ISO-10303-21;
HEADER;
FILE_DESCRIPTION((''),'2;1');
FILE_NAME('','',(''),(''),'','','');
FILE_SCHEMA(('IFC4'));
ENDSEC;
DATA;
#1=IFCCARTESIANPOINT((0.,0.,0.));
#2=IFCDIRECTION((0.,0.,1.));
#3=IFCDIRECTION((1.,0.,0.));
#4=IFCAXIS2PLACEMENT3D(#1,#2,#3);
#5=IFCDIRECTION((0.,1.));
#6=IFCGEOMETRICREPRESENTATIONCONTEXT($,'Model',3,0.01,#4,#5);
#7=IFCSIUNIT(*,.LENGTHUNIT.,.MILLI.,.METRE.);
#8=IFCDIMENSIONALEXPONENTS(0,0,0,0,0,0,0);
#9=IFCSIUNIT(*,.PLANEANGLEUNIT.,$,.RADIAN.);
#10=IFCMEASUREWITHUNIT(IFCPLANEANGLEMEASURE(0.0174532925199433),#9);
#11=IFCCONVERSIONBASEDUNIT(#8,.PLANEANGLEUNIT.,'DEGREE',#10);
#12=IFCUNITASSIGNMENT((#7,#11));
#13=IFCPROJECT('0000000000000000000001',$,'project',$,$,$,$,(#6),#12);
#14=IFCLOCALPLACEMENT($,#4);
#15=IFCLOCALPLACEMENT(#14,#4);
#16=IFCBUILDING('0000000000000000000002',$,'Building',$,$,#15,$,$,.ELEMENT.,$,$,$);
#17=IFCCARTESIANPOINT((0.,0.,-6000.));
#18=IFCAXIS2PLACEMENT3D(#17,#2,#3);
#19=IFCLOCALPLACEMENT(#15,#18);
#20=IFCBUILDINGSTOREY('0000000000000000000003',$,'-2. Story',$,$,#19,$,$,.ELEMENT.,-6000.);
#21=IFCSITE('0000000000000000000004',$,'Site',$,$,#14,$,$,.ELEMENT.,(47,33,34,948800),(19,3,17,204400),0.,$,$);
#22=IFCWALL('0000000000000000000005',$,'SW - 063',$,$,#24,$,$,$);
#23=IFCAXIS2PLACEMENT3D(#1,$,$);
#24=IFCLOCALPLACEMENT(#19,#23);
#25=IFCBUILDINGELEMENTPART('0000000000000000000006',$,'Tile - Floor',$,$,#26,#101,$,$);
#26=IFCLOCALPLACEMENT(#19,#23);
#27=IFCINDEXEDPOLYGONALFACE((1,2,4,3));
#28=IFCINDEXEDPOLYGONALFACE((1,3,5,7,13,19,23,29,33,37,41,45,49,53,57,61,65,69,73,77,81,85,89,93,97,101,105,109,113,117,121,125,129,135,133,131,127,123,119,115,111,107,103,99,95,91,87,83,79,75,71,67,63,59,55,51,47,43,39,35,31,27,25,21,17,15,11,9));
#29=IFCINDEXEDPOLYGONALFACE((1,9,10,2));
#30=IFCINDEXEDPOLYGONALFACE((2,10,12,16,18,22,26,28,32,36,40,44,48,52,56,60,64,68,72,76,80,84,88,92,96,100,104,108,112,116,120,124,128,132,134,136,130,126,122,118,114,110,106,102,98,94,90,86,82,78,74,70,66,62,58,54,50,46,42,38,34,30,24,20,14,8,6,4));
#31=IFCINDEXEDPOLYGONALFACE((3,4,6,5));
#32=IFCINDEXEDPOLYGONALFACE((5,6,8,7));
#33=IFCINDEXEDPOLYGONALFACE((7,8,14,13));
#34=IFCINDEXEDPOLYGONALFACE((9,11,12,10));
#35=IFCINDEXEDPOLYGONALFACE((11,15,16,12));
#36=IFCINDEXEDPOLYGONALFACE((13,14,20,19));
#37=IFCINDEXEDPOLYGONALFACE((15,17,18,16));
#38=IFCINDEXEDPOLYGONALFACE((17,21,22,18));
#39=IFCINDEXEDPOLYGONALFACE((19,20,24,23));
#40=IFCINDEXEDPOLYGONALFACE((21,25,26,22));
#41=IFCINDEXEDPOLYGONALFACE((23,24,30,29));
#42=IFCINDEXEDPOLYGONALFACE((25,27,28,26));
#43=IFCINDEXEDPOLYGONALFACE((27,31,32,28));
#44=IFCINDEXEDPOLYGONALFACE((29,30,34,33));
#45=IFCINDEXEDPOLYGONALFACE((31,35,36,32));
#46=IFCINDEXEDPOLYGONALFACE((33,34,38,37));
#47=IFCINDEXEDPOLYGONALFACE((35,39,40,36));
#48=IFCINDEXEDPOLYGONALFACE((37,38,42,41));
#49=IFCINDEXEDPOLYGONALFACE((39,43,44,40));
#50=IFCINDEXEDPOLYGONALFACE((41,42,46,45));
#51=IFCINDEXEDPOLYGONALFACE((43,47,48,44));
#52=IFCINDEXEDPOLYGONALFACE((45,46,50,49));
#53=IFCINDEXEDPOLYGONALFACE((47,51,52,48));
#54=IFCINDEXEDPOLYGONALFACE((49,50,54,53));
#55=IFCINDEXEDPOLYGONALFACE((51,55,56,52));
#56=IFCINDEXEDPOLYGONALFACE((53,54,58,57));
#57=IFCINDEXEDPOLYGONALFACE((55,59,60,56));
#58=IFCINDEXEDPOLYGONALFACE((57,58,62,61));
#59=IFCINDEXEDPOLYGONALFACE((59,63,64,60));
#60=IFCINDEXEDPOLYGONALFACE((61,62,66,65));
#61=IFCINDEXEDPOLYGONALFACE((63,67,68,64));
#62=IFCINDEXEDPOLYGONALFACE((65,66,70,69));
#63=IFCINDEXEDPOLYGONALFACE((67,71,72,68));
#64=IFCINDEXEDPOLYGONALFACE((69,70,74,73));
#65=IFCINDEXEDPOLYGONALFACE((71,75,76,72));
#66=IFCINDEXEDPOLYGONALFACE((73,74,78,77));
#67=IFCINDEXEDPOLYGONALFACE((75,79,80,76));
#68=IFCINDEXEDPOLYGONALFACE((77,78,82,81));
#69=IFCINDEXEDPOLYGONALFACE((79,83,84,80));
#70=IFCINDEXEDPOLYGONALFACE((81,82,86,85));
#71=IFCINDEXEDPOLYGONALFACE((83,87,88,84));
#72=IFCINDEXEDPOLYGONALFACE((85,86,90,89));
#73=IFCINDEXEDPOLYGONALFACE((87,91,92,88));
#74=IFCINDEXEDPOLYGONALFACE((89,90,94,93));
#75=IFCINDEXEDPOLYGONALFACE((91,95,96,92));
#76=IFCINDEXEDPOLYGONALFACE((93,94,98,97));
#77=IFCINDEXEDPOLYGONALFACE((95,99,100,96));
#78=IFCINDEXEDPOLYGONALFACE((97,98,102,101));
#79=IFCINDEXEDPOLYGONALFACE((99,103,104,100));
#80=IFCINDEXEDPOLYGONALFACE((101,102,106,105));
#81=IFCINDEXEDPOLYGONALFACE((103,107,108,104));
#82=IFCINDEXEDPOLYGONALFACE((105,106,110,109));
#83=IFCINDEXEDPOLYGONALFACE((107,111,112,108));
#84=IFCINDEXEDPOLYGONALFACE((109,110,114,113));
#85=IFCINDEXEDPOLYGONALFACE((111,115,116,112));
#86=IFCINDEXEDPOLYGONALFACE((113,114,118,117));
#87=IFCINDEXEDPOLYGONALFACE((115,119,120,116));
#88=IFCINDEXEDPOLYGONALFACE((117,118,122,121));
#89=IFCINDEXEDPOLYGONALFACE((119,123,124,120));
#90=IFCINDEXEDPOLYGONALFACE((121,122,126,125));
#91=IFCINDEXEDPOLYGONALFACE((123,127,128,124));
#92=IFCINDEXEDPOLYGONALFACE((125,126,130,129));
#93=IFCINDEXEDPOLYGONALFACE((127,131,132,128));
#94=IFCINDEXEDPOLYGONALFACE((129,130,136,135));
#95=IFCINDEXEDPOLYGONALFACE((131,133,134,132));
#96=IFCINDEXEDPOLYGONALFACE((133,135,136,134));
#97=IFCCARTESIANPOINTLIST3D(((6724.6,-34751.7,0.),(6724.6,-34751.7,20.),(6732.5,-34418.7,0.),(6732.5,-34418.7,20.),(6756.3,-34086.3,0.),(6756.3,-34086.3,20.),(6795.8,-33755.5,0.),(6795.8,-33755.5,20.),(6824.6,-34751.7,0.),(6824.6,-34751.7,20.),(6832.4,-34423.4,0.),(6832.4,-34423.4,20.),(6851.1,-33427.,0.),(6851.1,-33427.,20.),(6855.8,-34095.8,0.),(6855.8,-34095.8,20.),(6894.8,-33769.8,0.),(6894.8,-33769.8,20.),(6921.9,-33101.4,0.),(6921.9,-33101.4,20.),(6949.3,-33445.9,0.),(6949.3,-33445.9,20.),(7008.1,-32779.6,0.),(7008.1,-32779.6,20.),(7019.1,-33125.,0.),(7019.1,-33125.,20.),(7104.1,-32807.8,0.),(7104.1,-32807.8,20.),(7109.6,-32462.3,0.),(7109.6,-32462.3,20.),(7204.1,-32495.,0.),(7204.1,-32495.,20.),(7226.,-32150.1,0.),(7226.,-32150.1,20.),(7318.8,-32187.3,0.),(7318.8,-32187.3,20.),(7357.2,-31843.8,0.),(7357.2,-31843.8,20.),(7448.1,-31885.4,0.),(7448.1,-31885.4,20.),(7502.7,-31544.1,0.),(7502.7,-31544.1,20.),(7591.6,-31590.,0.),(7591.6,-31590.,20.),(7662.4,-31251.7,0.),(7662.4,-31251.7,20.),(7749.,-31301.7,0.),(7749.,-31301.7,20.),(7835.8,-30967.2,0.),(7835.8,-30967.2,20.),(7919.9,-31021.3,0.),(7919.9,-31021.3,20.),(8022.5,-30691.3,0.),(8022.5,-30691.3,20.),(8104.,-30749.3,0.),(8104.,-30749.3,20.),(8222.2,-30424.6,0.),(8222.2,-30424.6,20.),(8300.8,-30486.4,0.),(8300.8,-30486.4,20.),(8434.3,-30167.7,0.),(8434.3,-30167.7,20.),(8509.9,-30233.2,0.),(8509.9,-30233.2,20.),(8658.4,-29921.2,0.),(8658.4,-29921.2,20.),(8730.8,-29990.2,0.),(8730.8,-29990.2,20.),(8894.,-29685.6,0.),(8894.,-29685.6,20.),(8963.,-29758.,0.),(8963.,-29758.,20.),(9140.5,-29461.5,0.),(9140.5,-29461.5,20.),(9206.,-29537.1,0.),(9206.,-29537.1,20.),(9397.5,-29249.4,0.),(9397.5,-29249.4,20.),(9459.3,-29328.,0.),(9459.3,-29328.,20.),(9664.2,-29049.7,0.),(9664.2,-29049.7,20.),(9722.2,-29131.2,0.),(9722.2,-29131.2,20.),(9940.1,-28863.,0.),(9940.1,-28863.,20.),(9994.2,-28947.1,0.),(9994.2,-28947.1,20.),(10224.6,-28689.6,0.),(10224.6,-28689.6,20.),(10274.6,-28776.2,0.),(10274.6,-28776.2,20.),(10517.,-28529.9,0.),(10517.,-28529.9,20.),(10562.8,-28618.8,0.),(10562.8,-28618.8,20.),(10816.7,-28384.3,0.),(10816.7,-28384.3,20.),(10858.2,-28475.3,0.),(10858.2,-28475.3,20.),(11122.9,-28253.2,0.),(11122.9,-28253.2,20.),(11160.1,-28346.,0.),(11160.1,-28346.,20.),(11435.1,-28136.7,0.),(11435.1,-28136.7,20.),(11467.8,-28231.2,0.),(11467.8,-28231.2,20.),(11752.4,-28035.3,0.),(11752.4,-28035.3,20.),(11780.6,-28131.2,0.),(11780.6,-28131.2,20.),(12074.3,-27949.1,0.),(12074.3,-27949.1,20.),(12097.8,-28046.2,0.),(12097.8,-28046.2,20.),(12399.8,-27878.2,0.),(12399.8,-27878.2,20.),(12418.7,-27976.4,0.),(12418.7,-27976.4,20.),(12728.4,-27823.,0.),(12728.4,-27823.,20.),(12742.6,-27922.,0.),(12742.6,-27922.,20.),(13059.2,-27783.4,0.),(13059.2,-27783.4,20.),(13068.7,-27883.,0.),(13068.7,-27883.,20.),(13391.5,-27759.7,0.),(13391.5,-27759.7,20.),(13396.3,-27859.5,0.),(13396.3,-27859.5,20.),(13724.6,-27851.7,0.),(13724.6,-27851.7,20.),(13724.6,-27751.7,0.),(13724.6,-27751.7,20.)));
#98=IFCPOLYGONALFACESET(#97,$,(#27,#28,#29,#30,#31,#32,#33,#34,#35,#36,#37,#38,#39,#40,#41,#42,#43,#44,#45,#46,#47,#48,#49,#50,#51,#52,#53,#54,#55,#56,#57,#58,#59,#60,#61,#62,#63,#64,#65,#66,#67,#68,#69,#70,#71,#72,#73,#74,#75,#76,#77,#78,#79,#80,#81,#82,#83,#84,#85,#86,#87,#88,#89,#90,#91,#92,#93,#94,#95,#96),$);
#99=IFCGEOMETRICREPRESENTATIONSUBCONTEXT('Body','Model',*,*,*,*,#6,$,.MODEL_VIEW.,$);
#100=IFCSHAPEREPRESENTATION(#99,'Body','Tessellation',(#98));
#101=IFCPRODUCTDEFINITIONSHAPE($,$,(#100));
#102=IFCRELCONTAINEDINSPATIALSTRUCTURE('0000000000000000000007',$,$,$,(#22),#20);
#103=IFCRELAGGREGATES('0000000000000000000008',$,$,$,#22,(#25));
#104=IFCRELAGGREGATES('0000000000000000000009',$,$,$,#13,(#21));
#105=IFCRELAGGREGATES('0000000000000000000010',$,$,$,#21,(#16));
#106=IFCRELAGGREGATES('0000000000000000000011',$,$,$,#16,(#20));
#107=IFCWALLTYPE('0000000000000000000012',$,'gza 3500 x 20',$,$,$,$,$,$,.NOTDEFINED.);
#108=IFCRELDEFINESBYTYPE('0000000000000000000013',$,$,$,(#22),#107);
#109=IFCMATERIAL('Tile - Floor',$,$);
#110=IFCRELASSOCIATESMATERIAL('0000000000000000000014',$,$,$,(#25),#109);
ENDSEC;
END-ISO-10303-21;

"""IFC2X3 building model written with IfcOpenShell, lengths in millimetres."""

from ifc_helpers import new_model, entity, si_unit, converted_unit, direction, frame, origin_with_axes, place, context, subcontext, project, spatial, material, type_object, element, aggregate, save


model = new_model("IFC2X3")

# Units and contexts
model_context = context("Model", 3, precision=0.01, world=origin_with_axes(), true_north=direction((0.0, 1.0)))
body_context = subcontext(model_context, "Body", "Model", "MODEL_VIEW")
ifc_project = project(units=[si_unit("LENGTHUNIT", "METRE", prefix="MILLI"), converted_unit("PLANEANGLEUNIT", "DEGREE", entity("IfcPlaneAngleMeasure", 0.0174532925199433), si_unit("PLANEANGLEUNIT", "RADIAN"), dimensions=[0, 0, 0, 0, 0, 0, 0])], contexts=[model_context])

# Site, building, storey
site_placement = place(None, origin_with_axes())
site = spatial("IfcSite", under=ifc_project, at=site_placement, Name="Site", CompositionType="ELEMENT", RefLatitude=(47, 33, 34, 948800), RefLongitude=(19, 3, 17, 204400), RefElevation=0.0)
building_placement = place(site_placement, origin_with_axes())
building = spatial("IfcBuilding", under=site, at=building_placement, Name="Building", CompositionType="ELEMENT")
storey_placement = place(building_placement, frame((0.0, 0.0, -6000.0), z_axis=(0.0, 0.0, 1.0), x_axis=(1.0, 0.0, 0.0)))
storey = spatial("IfcBuildingStorey", under=building, at=storey_placement, Name="-2. Story", CompositionType="ELEMENT", Elevation=-6000.0)

# Wall, building element part
wall_type_1 = type_object("IfcWallType", Name="gza 3500 x 20", PredefinedType="NOTDEFINED")
wall_1_placement = place(storey_placement, frame((13724.6, -27751.7, 0.0), z_axis=(0.0, 0.0, 1.0), x_axis=(-1.0, 0.0, 0.0)))
wall_1 = element("IfcWall", 1, at=wall_1_placement, inside=storey, type_object=wall_type_1, Name="SW - 063")
ifc_material_1 = material(Name="Tile - Floor")
building_element_part_1_placement = place(wall_1_placement, origin_with_axes())
cartesian_point_1 = entity("IfcCartesianPoint", [100.0, 0.0])
building_element_part_1 = element("IfcBuildingElementPart", 2, at=building_element_part_1_placement, material=ifc_material_1, Name="Tile - Floor", context=body_context, shape_type="SweptSolid", body=[
    entity("IfcRevolvedAreaSolid", entity("IfcArbitraryClosedProfileDef", "AREA", None, entity("IfcPolyline", [cartesian_point_1, entity("IfcCartesianPoint", [100.0, 20.0]), entity("IfcCartesianPoint", [0.0, 20.0]), entity("IfcCartesianPoint", [0.0, 0.0]), cartesian_point_1])), entity("IfcAxis2Placement3D", entity("IfcCartesianPoint", [0.0, 0.0, 0.0]), entity("IfcDirection", [1.0, 0.0, 0.0]), entity("IfcDirection", [0.0, 1.0, 0.0])), entity("IfcAxis1Placement", entity("IfcCartesianPoint", [7000.0, 0.0, 0.0]), entity("IfcDirection", [0.0, 1.0, 0.0])), 90.0),
])
aggregate(wall_1, [building_element_part_1])

save(model, "model.ifc")
